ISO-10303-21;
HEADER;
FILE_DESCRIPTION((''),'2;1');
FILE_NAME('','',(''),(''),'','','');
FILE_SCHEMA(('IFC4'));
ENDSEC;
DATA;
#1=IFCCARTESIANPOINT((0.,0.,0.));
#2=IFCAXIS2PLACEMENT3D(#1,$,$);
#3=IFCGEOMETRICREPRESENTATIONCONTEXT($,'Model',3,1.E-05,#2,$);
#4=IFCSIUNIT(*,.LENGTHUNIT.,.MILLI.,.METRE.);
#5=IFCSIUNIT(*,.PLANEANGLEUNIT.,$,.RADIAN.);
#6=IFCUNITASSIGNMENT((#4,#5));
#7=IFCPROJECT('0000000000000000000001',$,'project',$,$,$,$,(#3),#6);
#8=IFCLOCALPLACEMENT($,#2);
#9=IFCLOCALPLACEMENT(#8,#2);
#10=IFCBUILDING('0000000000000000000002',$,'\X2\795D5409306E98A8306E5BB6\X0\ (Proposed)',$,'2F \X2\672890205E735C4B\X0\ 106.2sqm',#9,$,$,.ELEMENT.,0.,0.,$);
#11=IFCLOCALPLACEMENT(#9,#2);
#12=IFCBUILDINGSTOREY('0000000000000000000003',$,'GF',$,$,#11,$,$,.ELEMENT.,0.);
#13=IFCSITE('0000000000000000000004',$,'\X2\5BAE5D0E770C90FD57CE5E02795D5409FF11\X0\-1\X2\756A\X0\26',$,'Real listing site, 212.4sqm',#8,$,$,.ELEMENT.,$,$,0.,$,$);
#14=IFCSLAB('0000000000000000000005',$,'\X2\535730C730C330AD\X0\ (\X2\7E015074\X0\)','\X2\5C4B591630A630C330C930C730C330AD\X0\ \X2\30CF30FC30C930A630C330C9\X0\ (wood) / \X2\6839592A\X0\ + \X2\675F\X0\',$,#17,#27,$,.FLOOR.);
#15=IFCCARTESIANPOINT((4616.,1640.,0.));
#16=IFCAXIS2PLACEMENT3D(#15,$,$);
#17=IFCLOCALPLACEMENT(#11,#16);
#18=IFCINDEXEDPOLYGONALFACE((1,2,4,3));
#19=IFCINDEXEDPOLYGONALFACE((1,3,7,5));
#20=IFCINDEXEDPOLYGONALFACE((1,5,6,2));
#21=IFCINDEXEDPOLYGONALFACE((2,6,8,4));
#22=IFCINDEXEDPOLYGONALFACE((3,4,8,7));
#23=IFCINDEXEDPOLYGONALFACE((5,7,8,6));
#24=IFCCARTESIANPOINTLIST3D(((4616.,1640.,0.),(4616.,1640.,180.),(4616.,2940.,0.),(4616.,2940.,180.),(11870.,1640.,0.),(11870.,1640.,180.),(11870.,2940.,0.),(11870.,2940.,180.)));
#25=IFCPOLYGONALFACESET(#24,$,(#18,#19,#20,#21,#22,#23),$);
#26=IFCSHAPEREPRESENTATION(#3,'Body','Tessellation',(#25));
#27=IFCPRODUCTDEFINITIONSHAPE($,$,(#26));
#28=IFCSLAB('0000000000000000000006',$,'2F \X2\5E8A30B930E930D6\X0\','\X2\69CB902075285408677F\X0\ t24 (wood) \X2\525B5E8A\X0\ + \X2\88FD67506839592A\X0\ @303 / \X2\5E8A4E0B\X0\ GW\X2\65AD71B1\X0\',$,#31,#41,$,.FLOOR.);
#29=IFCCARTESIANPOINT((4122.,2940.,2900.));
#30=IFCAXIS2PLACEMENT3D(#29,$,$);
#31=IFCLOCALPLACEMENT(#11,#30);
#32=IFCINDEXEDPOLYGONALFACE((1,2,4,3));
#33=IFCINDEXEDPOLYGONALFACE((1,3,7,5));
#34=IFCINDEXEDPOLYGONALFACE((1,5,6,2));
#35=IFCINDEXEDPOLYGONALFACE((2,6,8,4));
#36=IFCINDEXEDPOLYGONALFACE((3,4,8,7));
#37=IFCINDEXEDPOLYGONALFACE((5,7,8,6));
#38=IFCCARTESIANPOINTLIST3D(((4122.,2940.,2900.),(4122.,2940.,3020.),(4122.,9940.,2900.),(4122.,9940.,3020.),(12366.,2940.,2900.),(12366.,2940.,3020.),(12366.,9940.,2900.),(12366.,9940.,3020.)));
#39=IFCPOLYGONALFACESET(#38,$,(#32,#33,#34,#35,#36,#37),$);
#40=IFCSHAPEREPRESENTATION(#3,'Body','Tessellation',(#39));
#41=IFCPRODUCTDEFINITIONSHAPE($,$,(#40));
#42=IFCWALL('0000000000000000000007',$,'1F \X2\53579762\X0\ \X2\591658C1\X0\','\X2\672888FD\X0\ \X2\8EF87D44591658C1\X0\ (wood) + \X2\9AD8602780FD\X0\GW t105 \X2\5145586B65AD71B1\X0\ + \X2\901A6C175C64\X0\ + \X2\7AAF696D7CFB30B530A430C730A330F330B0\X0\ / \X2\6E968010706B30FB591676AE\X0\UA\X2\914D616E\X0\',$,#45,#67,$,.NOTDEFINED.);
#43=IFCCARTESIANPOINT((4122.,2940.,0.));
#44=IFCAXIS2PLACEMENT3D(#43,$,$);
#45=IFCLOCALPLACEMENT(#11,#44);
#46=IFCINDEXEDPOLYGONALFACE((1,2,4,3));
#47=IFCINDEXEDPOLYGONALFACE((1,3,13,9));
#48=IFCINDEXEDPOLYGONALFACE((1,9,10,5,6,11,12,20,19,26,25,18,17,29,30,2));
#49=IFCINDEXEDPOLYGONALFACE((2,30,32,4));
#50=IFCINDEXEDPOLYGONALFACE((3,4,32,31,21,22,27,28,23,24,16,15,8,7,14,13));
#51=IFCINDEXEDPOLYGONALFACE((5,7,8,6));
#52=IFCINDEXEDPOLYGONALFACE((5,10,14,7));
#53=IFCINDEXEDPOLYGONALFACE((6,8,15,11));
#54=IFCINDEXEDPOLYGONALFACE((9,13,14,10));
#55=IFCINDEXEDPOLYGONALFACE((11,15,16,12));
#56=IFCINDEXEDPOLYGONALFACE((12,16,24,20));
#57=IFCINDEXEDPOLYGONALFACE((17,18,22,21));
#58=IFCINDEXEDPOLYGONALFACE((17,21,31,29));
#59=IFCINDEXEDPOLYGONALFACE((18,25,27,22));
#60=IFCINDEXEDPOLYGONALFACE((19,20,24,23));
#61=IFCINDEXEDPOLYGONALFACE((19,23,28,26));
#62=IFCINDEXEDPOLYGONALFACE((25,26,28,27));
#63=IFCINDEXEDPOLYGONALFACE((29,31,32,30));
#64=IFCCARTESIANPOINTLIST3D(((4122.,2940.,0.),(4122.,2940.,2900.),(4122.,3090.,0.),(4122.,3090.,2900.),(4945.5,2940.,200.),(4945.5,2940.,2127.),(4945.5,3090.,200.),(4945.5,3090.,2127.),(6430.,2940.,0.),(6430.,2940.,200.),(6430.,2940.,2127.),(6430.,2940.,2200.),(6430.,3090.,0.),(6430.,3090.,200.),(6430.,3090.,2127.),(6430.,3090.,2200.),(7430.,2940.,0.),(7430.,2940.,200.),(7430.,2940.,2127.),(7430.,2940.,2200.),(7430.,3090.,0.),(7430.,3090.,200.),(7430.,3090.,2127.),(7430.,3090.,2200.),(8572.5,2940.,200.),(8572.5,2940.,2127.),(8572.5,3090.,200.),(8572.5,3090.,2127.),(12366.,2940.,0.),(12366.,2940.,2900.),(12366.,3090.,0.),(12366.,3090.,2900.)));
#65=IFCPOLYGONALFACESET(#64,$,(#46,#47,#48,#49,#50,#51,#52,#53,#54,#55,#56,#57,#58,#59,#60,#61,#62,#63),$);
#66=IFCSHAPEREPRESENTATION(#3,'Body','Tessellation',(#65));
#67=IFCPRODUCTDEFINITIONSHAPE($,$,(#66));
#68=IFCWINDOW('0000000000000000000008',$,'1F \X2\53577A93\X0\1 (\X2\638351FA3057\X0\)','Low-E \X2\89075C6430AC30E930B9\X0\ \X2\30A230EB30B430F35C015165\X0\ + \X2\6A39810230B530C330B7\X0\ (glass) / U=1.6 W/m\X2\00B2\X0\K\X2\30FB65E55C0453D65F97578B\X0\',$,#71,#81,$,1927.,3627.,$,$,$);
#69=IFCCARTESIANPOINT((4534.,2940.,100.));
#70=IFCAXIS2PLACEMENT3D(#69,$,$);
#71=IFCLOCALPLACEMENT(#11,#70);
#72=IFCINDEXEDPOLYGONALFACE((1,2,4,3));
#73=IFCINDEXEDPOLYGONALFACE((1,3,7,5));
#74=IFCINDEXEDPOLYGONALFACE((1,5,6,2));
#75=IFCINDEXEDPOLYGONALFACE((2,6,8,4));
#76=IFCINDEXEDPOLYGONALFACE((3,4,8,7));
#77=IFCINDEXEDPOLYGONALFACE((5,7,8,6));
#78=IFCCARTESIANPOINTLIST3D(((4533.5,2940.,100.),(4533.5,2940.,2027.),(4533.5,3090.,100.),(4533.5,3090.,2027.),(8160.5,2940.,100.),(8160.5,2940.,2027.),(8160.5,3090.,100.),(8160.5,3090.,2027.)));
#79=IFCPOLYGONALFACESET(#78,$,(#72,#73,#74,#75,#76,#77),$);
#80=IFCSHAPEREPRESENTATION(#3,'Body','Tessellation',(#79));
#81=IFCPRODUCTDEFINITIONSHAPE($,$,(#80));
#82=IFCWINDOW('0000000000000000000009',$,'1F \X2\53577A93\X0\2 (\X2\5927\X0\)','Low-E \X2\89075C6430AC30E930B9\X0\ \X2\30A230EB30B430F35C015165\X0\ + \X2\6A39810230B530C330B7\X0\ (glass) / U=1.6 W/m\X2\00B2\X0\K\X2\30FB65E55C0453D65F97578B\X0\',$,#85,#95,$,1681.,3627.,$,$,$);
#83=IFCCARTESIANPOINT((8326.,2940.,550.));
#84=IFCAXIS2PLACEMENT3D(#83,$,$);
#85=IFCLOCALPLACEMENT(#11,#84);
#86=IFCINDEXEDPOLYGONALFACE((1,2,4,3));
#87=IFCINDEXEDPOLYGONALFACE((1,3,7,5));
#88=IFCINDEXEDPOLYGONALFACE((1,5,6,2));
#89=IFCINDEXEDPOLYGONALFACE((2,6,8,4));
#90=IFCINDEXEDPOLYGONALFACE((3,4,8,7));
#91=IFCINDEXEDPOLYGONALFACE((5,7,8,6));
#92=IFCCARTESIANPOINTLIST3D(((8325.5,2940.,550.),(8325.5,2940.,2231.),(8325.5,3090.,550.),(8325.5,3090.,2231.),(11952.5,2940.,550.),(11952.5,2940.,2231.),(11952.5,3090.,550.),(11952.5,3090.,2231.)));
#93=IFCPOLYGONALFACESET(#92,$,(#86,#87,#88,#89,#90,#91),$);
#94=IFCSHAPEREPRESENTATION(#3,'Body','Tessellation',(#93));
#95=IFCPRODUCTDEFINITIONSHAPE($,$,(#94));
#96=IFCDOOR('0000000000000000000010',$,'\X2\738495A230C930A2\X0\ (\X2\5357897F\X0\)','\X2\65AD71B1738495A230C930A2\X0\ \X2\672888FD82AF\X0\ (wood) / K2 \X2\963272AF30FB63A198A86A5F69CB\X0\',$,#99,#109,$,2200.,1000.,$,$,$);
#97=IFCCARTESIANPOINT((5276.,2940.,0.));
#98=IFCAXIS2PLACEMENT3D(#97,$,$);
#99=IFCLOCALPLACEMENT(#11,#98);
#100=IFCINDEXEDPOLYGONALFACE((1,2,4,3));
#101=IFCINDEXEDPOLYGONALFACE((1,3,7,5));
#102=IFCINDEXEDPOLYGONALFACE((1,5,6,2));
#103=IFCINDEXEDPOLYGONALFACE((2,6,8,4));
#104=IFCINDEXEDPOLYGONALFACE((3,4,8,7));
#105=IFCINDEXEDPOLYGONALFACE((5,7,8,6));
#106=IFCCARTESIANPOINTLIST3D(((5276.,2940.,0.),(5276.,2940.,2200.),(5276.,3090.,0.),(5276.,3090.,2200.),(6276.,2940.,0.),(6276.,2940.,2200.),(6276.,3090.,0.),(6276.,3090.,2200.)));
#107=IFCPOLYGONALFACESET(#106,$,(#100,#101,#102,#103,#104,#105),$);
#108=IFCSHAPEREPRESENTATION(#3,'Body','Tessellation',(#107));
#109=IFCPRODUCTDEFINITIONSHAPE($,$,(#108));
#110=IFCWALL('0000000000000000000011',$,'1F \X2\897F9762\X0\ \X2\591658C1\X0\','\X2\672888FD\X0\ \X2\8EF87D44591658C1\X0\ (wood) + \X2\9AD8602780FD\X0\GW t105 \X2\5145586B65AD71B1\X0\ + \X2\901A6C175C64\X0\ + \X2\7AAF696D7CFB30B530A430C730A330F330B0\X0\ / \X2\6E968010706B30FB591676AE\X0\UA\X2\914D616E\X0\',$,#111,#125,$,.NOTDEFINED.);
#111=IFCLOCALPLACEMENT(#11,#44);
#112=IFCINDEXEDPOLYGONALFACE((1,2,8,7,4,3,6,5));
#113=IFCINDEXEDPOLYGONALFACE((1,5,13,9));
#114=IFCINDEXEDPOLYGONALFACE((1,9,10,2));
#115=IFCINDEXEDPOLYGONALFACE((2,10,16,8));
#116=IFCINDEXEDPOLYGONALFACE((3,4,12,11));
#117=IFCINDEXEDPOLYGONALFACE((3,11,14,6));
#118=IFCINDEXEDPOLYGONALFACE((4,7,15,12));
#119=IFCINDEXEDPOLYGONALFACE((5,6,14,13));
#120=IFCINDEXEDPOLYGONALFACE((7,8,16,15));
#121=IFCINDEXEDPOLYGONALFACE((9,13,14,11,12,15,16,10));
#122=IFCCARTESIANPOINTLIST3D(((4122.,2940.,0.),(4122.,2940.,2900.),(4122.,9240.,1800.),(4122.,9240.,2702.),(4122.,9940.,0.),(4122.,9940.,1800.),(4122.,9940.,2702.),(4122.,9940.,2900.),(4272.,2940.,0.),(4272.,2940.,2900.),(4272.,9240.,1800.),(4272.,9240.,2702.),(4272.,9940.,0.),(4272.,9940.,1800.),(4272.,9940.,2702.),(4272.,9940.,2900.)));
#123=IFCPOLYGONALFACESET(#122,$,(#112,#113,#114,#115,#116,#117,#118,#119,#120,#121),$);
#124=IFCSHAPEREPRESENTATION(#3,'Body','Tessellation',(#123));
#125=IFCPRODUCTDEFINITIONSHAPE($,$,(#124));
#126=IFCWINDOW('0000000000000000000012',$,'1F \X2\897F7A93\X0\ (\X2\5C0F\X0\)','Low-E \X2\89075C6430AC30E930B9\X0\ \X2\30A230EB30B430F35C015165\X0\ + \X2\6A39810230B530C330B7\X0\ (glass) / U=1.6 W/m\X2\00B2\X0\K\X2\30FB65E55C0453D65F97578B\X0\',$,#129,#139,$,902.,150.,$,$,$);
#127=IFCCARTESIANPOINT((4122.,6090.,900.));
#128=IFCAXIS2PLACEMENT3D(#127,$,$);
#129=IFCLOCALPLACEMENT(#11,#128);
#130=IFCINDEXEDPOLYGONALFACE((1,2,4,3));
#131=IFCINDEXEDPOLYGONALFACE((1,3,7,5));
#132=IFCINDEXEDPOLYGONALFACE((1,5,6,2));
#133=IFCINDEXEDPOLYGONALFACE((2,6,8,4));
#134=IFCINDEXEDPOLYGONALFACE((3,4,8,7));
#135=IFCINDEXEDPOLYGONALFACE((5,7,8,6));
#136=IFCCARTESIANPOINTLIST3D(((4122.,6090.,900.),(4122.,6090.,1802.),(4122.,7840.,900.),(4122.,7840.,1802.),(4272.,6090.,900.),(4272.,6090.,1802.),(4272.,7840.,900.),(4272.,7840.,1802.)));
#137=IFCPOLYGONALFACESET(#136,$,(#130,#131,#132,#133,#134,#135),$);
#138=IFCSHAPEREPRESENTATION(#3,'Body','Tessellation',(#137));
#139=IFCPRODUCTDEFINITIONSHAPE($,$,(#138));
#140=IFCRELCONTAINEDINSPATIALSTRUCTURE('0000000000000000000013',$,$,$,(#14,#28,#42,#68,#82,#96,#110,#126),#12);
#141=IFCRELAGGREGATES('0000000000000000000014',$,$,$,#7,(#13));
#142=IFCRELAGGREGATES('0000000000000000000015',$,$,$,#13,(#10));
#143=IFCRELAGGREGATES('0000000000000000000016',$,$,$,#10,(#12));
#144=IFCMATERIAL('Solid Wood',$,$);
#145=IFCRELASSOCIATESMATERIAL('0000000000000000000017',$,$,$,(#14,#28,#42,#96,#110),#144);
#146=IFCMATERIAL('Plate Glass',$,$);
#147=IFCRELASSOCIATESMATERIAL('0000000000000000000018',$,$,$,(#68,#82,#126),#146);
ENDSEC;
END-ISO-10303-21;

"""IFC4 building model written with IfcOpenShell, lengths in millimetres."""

from ifc_helpers import new_model, si_unit, frame, frame_2d, origin, place, context, project, spatial, rectangle, extrude, material, element, fill, save


model = new_model("IFC4")

# Units and contexts
model_context = context("Model", 3, precision=1e-05, world=origin())
ifc_project = project(units=[si_unit("LENGTHUNIT", "METRE", prefix="MILLI"), si_unit("PLANEANGLEUNIT", "RADIAN")], contexts=[model_context])

# Site, building, storey
site_placement = place(None, origin())
site = spatial("IfcSite", under=ifc_project, at=site_placement, Name="宮崎県都城市祝吉１-1番26", ObjectType="Real listing site, 212.4sqm", CompositionType="ELEMENT", RefElevation=0.0)
building_placement = place(site_placement, origin())
building = spatial("IfcBuilding", under=site, at=building_placement, Name="祝吉の風の家 (Proposed)", ObjectType="2F 木造平屋 106.2sqm", CompositionType="ELEMENT", ElevationOfRefHeight=0.0, ElevationOfTerrain=0.0)
storey_placement = place(building_placement, origin())
storey = spatial("IfcBuildingStorey", under=building, at=storey_placement, Name="GF", CompositionType="ELEMENT", Elevation=0.0)

# Slabs
ifc_material_1 = material(Name="Solid Wood")
slab_1_placement = place(storey_placement, frame((4616.0, 1640.0, 0.0)))
element("IfcSlab", 1, at=slab_1_placement, inside=storey, material=ifc_material_1, Name="南デッキ (縁側)", Description="屋外ウッドデッキ ハードウッド (wood) / 根太 + 束", PredefinedType="FLOOR", context=model_context, shape_type="SweptSolid", body=[
    extrude(rectangle(XDim=7254.0, YDim=1300.0, at=frame_2d((3627.0, 650.0))), frame((4616.0, 1640.0, 0.0)), (0.0, 0.0, 1.0), 180.0),
])
slab_2_placement = place(storey_placement, frame((4122.0, 2940.0, 2900.0)))
element("IfcSlab", 2, at=slab_2_placement, inside=storey, material=ifc_material_1, Name="2F 床スラブ", Description="構造用合板 t24 (wood) 剛床 + 製材根太 @303 / 床下 GW断熱", PredefinedType="FLOOR", context=model_context, shape_type="SweptSolid", body=[
    extrude(rectangle(XDim=8244.0, YDim=7000.0, at=frame_2d((4122.0, 3500.0))), frame((4122.0, 2940.0, 2900.0)), (0.0, 0.0, 1.0), 120.0),
])

# Wall, openings, windows, door
wall_1_placement = place(storey_placement, frame((4122.0, 2940.0, 0.0)))
wall_1 = element("IfcWall", 3, at=wall_1_placement, inside=storey, material=ifc_material_1, Name="1F 南面 外壁", Description="木製 軸組外壁 (wood) + 高性能GW t105 充填断熱 + 通気層 + 窯業系サイディング / 準耐火・外皮UA配慮", PredefinedType="NOTDEFINED", context=model_context, shape_type="SweptSolid", body=[
    extrude(rectangle(XDim=8244.0, YDim=150.0, at=frame_2d((4122.0, 75.0))), frame((4122.0, 2940.0, 0.0)), (0.0, 0.0, 1.0), 2900.0),
])
opening_1_placement = place(storey_placement, frame((4534.0, 2940.0, 100.0)))
opening_1 = element("IfcOpeningElement", 4, at=opening_1_placement, cuts=wall_1, PredefinedType="NOTDEFINED", context=model_context, shape_type="SweptSolid", body=[
    extrude(rectangle(XDim=3627.0, YDim=150.0, at=frame_2d((1813.0, 75.0))), frame((4534.0, 2940.0, 100.0)), (0.0, 0.0, 1.0), 1927.0),
])
opening_2_placement = place(storey_placement, frame((8326.0, 2940.0, 550.0)))
opening_2 = element("IfcOpeningElement", 5, at=opening_2_placement, cuts=wall_1, PredefinedType="NOTDEFINED", context=model_context, shape_type="SweptSolid", body=[
    extrude(rectangle(XDim=3627.0, YDim=150.0, at=frame_2d((1813.0, 75.0))), frame((8326.0, 2940.0, 550.0)), (0.0, 0.0, 1.0), 1681.0),
])
opening_3_placement = place(storey_placement, frame((5276.0, 2940.0, 0.0)))
opening_3 = element("IfcOpeningElement", 6, at=opening_3_placement, cuts=wall_1, PredefinedType="NOTDEFINED", context=model_context, shape_type="SweptSolid", body=[
    extrude(rectangle(XDim=1000.0, YDim=150.0, at=frame_2d((500.0, 75.0))), frame((5276.0, 2940.0, 0.0)), (0.0, 0.0, 1.0), 2200.0),
])
ifc_material_2 = material(Name="Plate Glass")
window_1_placement = place(storey_placement, frame((4534.0, 2940.0, 100.0)))
window_1 = element("IfcWindow", 7, at=window_1_placement, inside=storey, material=ifc_material_2, Name="1F 南窓1 (掃出し)", Description="Low-E 複層ガラス アルゴン封入 + 樹脂サッシ (glass) / U=1.6 W/m²K・日射取得型", OverallHeight=1927.0, OverallWidth=3627.0, context=model_context, shape_type="SweptSolid", body=[
    extrude(rectangle(XDim=3627.0, YDim=150.0, at=frame_2d((1813.0, 75.0))), frame((4534.0, 2940.0, 100.0)), (0.0, 0.0, 1.0), 1927.0),
])
fill(opening_1, window_1)
window_2_placement = place(storey_placement, frame((8326.0, 2940.0, 550.0)))
window_2 = element("IfcWindow", 8, at=window_2_placement, inside=storey, material=ifc_material_2, Name="1F 南窓2 (大)", Description="Low-E 複層ガラス アルゴン封入 + 樹脂サッシ (glass) / U=1.6 W/m²K・日射取得型", OverallHeight=1681.0, OverallWidth=3627.0, context=model_context, shape_type="SweptSolid", body=[
    extrude(rectangle(XDim=3627.0, YDim=150.0, at=frame_2d((1813.0, 75.0))), frame((8326.0, 2940.0, 550.0)), (0.0, 0.0, 1.0), 1681.0),
])
fill(opening_2, window_2)
door_placement = place(storey_placement, frame((5276.0, 2940.0, 0.0)))
door = element("IfcDoor", 9, at=door_placement, inside=storey, material=ifc_material_1, Name="玄関ドア (南西)", Description="断熱玄関ドア 木製芯 (wood) / K2 防犯・採風機構", OverallHeight=2200.0, OverallWidth=1000.0, context=model_context, shape_type="SweptSolid", body=[
    extrude(rectangle(XDim=1000.0, YDim=150.0, at=frame_2d((500.0, 75.0))), frame((5276.0, 2940.0, 0.0)), (0.0, 0.0, 1.0), 2200.0),
])
fill(opening_3, door)

# Wall, opening, window
wall_2_placement = place(storey_placement, frame((4122.0, 2940.0, 0.0)))
wall_2 = element("IfcWall", 10, at=wall_2_placement, inside=storey, material=ifc_material_1, Name="1F 西面 外壁", Description="木製 軸組外壁 (wood) + 高性能GW t105 充填断熱 + 通気層 + 窯業系サイディング / 準耐火・外皮UA配慮", PredefinedType="NOTDEFINED", context=model_context, shape_type="SweptSolid", body=[
    extrude(rectangle(XDim=150.0, YDim=7000.0, at=frame_2d((75.0, 3500.0))), frame((4122.0, 2940.0, 0.0)), (0.0, 0.0, 1.0), 2900.0),
])
opening_4_placement = place(storey_placement, frame((4122.0, 6090.0, 900.0)))
opening_4 = element("IfcOpeningElement", 11, at=opening_4_placement, cuts=wall_2, PredefinedType="NOTDEFINED", context=model_context, shape_type="SweptSolid", body=[
    extrude(rectangle(XDim=150.0, YDim=1750.0, at=frame_2d((75.0, 875.0))), frame((4122.0, 6090.0, 900.0)), (0.0, 0.0, 1.0), 902.0),
])
window_3_placement = place(storey_placement, frame((4122.0, 6090.0, 900.0)))
window_3 = element("IfcWindow", 12, at=window_3_placement, inside=storey, material=ifc_material_2, Name="1F 西窓 (小)", Description="Low-E 複層ガラス アルゴン封入 + 樹脂サッシ (glass) / U=1.6 W/m²K・日射取得型", OverallHeight=902.0, OverallWidth=150.0, context=model_context, shape_type="SweptSolid", body=[
    extrude(rectangle(XDim=150.0, YDim=1750.0, at=frame_2d((75.0, 875.0))), frame((4122.0, 6090.0, 900.0)), (0.0, 0.0, 1.0), 902.0),
])
fill(opening_4, window_3)

save(model, "model.ifc")
